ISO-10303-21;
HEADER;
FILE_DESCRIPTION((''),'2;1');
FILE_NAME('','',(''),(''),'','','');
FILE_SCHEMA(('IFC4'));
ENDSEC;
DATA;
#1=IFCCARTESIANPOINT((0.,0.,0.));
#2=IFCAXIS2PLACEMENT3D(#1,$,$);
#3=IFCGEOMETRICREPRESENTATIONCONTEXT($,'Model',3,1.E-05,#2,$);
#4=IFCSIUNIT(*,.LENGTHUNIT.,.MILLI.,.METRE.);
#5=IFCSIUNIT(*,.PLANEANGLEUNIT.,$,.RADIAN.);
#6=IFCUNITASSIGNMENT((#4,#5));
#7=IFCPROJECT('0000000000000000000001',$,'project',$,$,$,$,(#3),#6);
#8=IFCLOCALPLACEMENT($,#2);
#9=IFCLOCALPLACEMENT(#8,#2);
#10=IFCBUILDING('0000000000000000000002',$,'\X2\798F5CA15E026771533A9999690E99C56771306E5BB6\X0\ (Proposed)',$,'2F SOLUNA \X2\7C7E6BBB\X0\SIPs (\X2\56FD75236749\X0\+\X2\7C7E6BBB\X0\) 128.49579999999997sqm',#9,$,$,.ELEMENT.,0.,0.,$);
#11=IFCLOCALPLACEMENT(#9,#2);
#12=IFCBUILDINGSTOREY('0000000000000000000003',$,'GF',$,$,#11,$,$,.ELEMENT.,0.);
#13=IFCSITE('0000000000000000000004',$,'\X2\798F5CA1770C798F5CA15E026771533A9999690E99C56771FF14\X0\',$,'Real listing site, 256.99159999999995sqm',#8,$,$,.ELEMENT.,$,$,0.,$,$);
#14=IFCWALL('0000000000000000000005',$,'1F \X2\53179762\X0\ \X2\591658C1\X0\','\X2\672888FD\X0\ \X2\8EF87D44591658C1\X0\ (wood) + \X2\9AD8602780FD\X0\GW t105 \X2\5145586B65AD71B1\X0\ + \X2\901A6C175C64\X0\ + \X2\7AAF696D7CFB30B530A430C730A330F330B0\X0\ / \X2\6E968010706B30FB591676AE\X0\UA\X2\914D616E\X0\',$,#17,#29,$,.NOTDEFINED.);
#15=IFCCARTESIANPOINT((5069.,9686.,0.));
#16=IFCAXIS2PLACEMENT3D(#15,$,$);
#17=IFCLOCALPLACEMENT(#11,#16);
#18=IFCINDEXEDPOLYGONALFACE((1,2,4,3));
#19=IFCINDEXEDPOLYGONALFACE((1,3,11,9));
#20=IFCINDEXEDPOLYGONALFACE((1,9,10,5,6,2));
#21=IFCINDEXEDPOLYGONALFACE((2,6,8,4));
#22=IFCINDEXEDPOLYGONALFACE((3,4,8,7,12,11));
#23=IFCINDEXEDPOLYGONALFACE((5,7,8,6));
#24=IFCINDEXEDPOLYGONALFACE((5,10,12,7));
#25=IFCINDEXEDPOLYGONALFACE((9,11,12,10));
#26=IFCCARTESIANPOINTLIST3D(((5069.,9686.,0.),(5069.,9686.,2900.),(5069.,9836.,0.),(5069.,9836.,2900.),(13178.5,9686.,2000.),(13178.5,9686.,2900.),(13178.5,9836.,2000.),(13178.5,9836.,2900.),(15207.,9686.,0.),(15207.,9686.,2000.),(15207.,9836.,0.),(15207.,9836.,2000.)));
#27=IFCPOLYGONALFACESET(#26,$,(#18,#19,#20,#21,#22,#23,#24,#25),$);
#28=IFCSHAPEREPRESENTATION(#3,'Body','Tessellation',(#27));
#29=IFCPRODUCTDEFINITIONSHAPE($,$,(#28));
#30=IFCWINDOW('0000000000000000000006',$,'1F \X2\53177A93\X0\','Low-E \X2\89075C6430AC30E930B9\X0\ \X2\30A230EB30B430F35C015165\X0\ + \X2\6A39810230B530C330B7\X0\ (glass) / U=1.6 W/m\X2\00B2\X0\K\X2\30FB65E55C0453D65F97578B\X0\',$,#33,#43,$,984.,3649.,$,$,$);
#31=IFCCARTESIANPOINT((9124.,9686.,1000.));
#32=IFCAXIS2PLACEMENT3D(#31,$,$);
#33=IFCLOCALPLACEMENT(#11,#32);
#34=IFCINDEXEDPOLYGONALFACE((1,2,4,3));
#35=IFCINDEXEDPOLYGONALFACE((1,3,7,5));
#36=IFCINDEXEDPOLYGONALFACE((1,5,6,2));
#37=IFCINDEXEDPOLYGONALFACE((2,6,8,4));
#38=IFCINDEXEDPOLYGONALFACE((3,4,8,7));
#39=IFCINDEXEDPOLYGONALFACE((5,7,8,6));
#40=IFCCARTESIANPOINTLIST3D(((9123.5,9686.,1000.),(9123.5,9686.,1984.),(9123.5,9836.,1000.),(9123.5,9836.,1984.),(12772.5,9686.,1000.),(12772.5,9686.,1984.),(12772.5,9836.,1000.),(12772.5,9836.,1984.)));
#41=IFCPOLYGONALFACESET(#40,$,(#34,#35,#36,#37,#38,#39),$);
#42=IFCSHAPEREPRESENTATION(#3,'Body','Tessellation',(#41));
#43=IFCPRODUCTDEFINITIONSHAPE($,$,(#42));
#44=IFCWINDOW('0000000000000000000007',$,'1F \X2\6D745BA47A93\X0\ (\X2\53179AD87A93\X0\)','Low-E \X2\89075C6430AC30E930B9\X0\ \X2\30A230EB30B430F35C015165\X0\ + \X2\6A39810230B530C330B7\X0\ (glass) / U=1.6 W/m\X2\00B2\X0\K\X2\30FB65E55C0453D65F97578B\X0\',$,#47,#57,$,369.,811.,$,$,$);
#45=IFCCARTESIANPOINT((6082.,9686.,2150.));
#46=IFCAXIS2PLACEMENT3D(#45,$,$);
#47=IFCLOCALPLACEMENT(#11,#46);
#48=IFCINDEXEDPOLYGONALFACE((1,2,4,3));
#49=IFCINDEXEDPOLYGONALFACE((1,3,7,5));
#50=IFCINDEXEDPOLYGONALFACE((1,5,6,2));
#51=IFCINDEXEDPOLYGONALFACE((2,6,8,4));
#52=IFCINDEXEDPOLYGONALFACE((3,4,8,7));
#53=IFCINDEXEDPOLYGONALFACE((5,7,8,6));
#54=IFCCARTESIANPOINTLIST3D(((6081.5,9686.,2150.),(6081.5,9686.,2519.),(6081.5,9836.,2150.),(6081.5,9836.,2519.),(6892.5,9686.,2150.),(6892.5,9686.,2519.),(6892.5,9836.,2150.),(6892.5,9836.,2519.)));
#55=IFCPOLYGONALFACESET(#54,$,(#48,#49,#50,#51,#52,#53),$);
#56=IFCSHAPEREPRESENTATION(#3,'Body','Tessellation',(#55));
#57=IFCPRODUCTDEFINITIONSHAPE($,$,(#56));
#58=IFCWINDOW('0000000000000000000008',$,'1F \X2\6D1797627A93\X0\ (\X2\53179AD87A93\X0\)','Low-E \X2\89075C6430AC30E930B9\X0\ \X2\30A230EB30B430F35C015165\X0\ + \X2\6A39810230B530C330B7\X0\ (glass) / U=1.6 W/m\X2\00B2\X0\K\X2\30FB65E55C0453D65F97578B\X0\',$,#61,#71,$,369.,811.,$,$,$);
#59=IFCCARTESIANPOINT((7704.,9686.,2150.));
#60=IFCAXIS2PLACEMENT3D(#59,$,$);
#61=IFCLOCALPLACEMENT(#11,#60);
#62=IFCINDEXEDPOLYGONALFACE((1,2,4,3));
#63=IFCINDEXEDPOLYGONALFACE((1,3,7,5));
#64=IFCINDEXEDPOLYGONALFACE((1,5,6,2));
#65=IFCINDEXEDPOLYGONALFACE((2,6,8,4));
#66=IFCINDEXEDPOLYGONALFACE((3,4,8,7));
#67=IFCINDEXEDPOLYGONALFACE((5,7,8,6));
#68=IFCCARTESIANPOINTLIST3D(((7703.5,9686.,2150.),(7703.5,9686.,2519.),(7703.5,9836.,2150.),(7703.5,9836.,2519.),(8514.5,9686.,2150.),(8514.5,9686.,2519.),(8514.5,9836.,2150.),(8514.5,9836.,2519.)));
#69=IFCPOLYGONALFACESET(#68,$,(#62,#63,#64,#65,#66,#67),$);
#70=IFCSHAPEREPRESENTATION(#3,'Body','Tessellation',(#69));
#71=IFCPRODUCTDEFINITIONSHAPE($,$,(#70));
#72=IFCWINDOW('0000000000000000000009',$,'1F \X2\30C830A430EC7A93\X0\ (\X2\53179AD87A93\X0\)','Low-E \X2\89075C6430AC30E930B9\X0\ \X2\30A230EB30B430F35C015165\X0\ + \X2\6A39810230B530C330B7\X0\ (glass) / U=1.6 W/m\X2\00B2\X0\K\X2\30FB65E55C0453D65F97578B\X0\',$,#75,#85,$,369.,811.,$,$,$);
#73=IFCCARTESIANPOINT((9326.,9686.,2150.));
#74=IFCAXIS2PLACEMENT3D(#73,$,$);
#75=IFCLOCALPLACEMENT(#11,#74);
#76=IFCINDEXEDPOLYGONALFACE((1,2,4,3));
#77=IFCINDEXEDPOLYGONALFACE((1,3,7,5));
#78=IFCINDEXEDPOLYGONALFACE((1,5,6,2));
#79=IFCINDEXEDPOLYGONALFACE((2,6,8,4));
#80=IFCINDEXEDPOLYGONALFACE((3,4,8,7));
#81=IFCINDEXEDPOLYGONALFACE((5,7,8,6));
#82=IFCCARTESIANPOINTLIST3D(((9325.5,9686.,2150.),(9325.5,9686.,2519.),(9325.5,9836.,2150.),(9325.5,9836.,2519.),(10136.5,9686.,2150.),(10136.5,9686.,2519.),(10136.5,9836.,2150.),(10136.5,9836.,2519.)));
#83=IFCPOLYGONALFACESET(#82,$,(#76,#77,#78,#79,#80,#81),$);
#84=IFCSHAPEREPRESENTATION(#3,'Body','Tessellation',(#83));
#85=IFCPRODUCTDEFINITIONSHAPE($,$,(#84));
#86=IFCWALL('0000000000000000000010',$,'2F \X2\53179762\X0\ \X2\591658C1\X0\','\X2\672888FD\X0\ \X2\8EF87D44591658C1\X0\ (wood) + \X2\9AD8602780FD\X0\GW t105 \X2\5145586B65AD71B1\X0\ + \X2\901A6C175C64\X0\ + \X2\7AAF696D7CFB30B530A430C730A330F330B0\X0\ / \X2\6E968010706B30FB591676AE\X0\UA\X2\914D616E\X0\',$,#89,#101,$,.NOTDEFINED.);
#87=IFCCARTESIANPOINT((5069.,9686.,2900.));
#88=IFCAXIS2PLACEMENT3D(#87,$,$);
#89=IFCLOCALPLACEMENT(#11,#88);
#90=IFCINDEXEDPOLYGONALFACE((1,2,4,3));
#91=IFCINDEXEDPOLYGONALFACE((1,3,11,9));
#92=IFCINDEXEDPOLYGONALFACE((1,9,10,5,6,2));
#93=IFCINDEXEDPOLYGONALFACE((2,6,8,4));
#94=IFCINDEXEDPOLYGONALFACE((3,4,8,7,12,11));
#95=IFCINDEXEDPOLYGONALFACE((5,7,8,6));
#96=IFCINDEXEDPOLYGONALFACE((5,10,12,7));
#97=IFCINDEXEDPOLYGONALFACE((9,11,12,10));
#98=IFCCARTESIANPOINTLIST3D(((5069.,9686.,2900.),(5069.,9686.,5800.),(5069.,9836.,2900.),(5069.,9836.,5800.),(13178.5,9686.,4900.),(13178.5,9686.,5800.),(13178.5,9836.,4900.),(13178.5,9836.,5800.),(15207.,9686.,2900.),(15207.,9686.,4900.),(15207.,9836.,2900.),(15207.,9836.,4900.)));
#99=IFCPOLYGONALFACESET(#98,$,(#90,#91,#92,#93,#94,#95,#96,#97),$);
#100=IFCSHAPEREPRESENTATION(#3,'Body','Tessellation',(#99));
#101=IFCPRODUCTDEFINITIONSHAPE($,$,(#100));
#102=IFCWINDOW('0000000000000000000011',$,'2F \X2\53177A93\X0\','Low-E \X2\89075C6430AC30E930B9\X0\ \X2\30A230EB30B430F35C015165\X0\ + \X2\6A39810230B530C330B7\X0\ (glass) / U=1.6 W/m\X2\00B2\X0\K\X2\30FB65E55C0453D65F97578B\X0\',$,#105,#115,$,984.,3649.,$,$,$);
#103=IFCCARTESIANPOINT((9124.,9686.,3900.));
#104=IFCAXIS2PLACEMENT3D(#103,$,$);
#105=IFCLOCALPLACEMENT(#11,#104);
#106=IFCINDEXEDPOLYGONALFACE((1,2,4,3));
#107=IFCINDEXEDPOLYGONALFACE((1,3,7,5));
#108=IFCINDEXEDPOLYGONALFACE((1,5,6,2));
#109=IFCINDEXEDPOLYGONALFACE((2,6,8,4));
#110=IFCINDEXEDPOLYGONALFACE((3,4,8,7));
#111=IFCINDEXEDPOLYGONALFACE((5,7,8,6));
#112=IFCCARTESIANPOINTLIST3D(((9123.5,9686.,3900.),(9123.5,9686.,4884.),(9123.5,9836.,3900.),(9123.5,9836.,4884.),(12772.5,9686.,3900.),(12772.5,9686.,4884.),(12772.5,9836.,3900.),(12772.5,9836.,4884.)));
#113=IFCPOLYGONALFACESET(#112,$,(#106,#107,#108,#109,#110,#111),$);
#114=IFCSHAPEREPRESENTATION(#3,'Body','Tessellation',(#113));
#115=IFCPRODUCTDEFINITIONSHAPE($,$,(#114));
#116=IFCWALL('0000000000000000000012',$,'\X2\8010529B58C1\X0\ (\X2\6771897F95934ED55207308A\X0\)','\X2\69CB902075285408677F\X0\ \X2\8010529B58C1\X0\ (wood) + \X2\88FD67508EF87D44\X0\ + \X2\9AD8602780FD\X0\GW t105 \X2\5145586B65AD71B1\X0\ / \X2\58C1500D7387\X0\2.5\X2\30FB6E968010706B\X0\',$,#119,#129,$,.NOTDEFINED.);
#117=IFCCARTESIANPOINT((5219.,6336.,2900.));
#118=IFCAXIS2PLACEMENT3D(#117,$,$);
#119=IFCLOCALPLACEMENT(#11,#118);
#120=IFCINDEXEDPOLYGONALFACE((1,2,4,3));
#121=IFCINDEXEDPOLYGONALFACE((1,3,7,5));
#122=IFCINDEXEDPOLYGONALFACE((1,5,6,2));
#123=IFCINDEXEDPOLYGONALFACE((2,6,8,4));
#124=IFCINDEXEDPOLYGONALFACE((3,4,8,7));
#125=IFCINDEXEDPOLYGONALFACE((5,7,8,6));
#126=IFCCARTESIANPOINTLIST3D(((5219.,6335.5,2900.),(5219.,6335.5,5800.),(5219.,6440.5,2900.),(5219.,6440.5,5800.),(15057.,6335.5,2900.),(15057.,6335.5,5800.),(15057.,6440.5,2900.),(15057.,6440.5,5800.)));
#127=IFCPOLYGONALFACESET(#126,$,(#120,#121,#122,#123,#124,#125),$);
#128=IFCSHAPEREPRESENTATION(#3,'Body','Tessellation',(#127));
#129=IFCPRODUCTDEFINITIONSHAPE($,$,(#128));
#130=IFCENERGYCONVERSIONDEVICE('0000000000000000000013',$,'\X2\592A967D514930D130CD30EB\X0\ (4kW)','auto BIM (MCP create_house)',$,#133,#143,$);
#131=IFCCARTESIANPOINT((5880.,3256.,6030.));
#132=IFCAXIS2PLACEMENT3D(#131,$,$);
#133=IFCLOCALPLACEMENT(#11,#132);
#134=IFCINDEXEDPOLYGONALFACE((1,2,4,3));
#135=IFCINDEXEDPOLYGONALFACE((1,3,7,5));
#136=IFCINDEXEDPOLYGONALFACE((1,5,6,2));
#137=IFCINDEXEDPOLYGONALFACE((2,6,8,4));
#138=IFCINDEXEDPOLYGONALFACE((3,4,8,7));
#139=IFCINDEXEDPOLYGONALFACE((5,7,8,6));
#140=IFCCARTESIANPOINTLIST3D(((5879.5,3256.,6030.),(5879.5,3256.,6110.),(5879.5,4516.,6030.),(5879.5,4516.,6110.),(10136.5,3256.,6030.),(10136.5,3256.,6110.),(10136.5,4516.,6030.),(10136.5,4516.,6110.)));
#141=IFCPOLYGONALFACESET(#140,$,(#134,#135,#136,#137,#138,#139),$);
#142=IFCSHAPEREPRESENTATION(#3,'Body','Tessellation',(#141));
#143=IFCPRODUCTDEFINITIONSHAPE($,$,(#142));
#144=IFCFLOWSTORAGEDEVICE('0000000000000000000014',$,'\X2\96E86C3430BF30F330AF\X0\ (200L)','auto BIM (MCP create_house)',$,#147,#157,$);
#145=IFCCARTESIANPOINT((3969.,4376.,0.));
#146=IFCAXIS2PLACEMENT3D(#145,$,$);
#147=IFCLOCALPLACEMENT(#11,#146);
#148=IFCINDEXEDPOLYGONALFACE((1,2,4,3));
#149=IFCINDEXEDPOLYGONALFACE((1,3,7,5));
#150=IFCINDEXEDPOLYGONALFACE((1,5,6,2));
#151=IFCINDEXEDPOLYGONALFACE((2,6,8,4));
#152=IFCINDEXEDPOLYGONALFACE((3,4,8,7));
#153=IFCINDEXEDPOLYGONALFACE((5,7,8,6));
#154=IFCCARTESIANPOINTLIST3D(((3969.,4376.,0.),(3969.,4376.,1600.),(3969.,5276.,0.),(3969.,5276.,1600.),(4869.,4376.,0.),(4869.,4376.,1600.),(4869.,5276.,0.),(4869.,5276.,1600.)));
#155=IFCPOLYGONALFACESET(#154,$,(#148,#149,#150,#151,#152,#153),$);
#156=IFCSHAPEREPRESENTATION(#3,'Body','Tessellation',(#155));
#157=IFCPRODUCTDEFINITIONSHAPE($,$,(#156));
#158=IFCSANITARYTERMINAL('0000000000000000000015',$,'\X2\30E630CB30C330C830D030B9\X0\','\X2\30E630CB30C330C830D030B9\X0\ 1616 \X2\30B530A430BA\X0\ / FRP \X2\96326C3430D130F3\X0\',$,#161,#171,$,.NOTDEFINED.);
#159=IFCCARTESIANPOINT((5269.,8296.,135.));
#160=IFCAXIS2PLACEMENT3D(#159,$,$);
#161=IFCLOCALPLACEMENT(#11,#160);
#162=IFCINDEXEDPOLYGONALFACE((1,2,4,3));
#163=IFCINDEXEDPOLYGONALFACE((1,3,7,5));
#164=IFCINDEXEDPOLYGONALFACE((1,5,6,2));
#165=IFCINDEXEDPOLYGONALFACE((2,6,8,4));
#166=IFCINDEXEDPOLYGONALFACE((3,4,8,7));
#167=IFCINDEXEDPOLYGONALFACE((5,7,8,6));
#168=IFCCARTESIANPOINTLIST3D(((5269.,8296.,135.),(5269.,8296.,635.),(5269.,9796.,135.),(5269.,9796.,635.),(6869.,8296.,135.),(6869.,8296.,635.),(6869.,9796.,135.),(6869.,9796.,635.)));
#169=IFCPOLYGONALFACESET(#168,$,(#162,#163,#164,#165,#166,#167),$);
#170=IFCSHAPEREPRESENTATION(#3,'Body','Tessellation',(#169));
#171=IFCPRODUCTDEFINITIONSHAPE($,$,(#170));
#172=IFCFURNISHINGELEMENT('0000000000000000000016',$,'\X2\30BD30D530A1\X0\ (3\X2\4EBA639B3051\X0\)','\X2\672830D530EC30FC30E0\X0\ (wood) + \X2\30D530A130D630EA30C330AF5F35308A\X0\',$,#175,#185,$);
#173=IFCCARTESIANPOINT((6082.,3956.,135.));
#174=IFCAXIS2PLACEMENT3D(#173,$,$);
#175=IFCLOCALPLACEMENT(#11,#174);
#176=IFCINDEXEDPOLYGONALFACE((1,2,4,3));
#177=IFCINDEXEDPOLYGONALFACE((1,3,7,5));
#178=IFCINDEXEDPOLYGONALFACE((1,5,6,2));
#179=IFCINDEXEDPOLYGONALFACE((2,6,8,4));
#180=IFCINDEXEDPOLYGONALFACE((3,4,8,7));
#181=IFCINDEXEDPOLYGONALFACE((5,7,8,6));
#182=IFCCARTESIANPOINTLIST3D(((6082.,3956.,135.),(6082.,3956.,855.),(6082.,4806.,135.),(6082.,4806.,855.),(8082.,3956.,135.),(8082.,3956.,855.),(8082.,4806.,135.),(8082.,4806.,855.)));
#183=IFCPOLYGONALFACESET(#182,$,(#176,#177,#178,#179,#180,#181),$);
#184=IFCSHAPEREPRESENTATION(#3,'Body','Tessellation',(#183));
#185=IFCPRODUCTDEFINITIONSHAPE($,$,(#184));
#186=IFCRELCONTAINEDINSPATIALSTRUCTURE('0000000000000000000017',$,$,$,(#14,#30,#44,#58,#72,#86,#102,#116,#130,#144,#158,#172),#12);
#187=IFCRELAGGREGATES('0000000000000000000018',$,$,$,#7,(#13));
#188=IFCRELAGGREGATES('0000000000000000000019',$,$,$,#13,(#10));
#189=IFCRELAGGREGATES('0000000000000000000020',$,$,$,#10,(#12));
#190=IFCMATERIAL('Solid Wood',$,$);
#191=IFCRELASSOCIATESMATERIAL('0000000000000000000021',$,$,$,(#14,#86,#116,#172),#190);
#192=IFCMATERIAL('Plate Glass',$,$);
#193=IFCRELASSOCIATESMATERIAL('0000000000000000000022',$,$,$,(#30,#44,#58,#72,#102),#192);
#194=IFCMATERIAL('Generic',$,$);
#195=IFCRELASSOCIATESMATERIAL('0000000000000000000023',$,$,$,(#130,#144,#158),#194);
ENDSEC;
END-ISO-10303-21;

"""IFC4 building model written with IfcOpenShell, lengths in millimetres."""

from ifc_helpers import new_model, si_unit, frame, frame_2d, origin, place, context, project, spatial, rectangle, extrude, material, element, fill, save


model = new_model("IFC4")

# Units and contexts
model_context = context("Model", 3, precision=1e-05, world=origin())
ifc_project = project(units=[si_unit("LENGTHUNIT", "METRE", prefix="MILLI"), si_unit("PLANEANGLEUNIT", "RADIAN")], contexts=[model_context])

# Site, building, storey
site_placement = place(None, origin())
site = spatial("IfcSite", under=ifc_project, at=site_placement, Name="福岡県福岡市東区香椎駅東４", ObjectType="Real listing site, 256.99159999999995sqm", CompositionType="ELEMENT", RefElevation=0.0)
building_placement = place(site_placement, origin())
building = spatial("IfcBuilding", under=site, at=building_placement, Name="福岡市東区香椎駅東の家 (Proposed)", ObjectType="2F SOLUNA 籾殻SIPs (国産杉+籾殻) 128.49579999999997sqm", CompositionType="ELEMENT", ElevationOfRefHeight=0.0, ElevationOfTerrain=0.0)
storey_placement = place(building_placement, origin())
storey = spatial("IfcBuildingStorey", under=building, at=storey_placement, Name="GF", CompositionType="ELEMENT", Elevation=0.0)

# Wall, openings, windows
ifc_material_1 = material(Name="Solid Wood")
wall_1_placement = place(storey_placement, frame((5069.0, 9686.0, 0.0)))
wall_1 = element("IfcWall", 1, at=wall_1_placement, inside=storey, material=ifc_material_1, Name="1F 北面 外壁", Description="木製 軸組外壁 (wood) + 高性能GW t105 充填断熱 + 通気層 + 窯業系サイディング / 準耐火・外皮UA配慮", PredefinedType="NOTDEFINED", context=model_context, shape_type="SweptSolid", body=[
    extrude(rectangle(XDim=10138.0, YDim=150.0, at=frame_2d((5069.0, 75.0))), frame((5069.0, 9686.0, 0.0)), (0.0, 0.0, 1.0), 2900.0),
])
opening_1_placement = place(storey_placement, frame((9124.0, 9686.0, 1000.0)))
opening_1 = element("IfcOpeningElement", 2, at=opening_1_placement, cuts=wall_1, PredefinedType="NOTDEFINED", context=model_context, shape_type="SweptSolid", body=[
    extrude(rectangle(XDim=3649.0, YDim=150.0, at=frame_2d((1824.0, 75.0))), frame((9124.0, 9686.0, 1000.0)), (0.0, 0.0, 1.0), 984.0),
])
opening_2_placement = place(storey_placement, frame((6082.0, 9686.0, 2150.0)))
opening_2 = element("IfcOpeningElement", 3, at=opening_2_placement, cuts=wall_1, PredefinedType="NOTDEFINED", context=model_context, shape_type="SweptSolid", body=[
    extrude(rectangle(XDim=811.0, YDim=150.0, at=frame_2d((405.0, 75.0))), frame((6082.0, 9686.0, 2150.0)), (0.0, 0.0, 1.0), 369.0),
])
opening_3_placement = place(storey_placement, frame((7704.0, 9686.0, 2150.0)))
opening_3 = element("IfcOpeningElement", 4, at=opening_3_placement, cuts=wall_1, PredefinedType="NOTDEFINED", context=model_context, shape_type="SweptSolid", body=[
    extrude(rectangle(XDim=811.0, YDim=150.0, at=frame_2d((405.0, 75.0))), frame((7704.0, 9686.0, 2150.0)), (0.0, 0.0, 1.0), 369.0),
])
opening_4_placement = place(storey_placement, frame((9326.0, 9686.0, 2150.0)))
opening_4 = element("IfcOpeningElement", 5, at=opening_4_placement, cuts=wall_1, PredefinedType="NOTDEFINED", context=model_context, shape_type="SweptSolid", body=[
    extrude(rectangle(XDim=811.0, YDim=150.0, at=frame_2d((405.0, 75.0))), frame((9326.0, 9686.0, 2150.0)), (0.0, 0.0, 1.0), 369.0),
])
ifc_material_2 = material(Name="Plate Glass")
window_1_placement = place(storey_placement, frame((9124.0, 9686.0, 1000.0)))
window_1 = element("IfcWindow", 6, at=window_1_placement, inside=storey, material=ifc_material_2, Name="1F 北窓", Description="Low-E 複層ガラス アルゴン封入 + 樹脂サッシ (glass) / U=1.6 W/m²K・日射取得型", OverallHeight=984.0, OverallWidth=3649.0, context=model_context, shape_type="SweptSolid", body=[
    extrude(rectangle(XDim=3649.0, YDim=150.0, at=frame_2d((1824.0, 75.0))), frame((9124.0, 9686.0, 1000.0)), (0.0, 0.0, 1.0), 984.0),
])
fill(opening_1, window_1)
window_2_placement = place(storey_placement, frame((6082.0, 9686.0, 2150.0)))
window_2 = element("IfcWindow", 7, at=window_2_placement, inside=storey, material=ifc_material_2, Name="1F 浴室窓 (北高窓)", Description="Low-E 複層ガラス アルゴン封入 + 樹脂サッシ (glass) / U=1.6 W/m²K・日射取得型", OverallHeight=369.0, OverallWidth=811.0, context=model_context, shape_type="SweptSolid", body=[
    extrude(rectangle(XDim=811.0, YDim=150.0, at=frame_2d((405.0, 75.0))), frame((6082.0, 9686.0, 2150.0)), (0.0, 0.0, 1.0), 369.0),
])
fill(opening_2, window_2)
window_3_placement = place(storey_placement, frame((7704.0, 9686.0, 2150.0)))
window_3 = element("IfcWindow", 8, at=window_3_placement, inside=storey, material=ifc_material_2, Name="1F 洗面窓 (北高窓)", Description="Low-E 複層ガラス アルゴン封入 + 樹脂サッシ (glass) / U=1.6 W/m²K・日射取得型", OverallHeight=369.0, OverallWidth=811.0, context=model_context, shape_type="SweptSolid", body=[
    extrude(rectangle(XDim=811.0, YDim=150.0, at=frame_2d((405.0, 75.0))), frame((7704.0, 9686.0, 2150.0)), (0.0, 0.0, 1.0), 369.0),
])
fill(opening_3, window_3)
window_4_placement = place(storey_placement, frame((9326.0, 9686.0, 2150.0)))
window_4 = element("IfcWindow", 9, at=window_4_placement, inside=storey, material=ifc_material_2, Name="1F トイレ窓 (北高窓)", Description="Low-E 複層ガラス アルゴン封入 + 樹脂サッシ (glass) / U=1.6 W/m²K・日射取得型", OverallHeight=369.0, OverallWidth=811.0, context=model_context, shape_type="SweptSolid", body=[
    extrude(rectangle(XDim=811.0, YDim=150.0, at=frame_2d((405.0, 75.0))), frame((9326.0, 9686.0, 2150.0)), (0.0, 0.0, 1.0), 369.0),
])
fill(opening_4, window_4)

# Wall, opening, window
wall_2_placement = place(storey_placement, frame((5069.0, 9686.0, 2900.0)))
wall_2 = element("IfcWall", 10, at=wall_2_placement, inside=storey, material=ifc_material_1, Name="2F 北面 外壁", Description="木製 軸組外壁 (wood) + 高性能GW t105 充填断熱 + 通気層 + 窯業系サイディング / 準耐火・外皮UA配慮", PredefinedType="NOTDEFINED", context=model_context, shape_type="SweptSolid", body=[
    extrude(rectangle(XDim=10138.0, YDim=150.0, at=frame_2d((5069.0, 75.0))), frame((5069.0, 9686.0, 2900.0)), (0.0, 0.0, 1.0), 2900.0),
])
opening_5_placement = place(storey_placement, frame((9124.0, 9686.0, 3900.0)))
opening_5 = element("IfcOpeningElement", 11, at=opening_5_placement, cuts=wall_2, PredefinedType="NOTDEFINED", context=model_context, shape_type="SweptSolid", body=[
    extrude(rectangle(XDim=3649.0, YDim=150.0, at=frame_2d((1824.0, 75.0))), frame((9124.0, 9686.0, 3900.0)), (0.0, 0.0, 1.0), 984.0),
])
window_5_placement = place(storey_placement, frame((9124.0, 9686.0, 3900.0)))
window_5 = element("IfcWindow", 12, at=window_5_placement, inside=storey, material=ifc_material_2, Name="2F 北窓", Description="Low-E 複層ガラス アルゴン封入 + 樹脂サッシ (glass) / U=1.6 W/m²K・日射取得型", OverallHeight=984.0, OverallWidth=3649.0, context=model_context, shape_type="SweptSolid", body=[
    extrude(rectangle(XDim=3649.0, YDim=150.0, at=frame_2d((1824.0, 75.0))), frame((9124.0, 9686.0, 3900.0)), (0.0, 0.0, 1.0), 984.0),
])
fill(opening_5, window_5)

# Wall
wall_3_placement = place(storey_placement, frame((5219.0, 6336.0, 2900.0)))
element("IfcWall", 13, at=wall_3_placement, inside=storey, material=ifc_material_1, Name="耐力壁 (東西間仕切り)", Description="構造用合板 耐力壁 (wood) + 製材軸組 + 高性能GW t105 充填断熱 / 壁倍率2.5・準耐火", PredefinedType="NOTDEFINED", context=model_context, shape_type="SweptSolid", body=[
    extrude(rectangle(XDim=9838.0, YDim=105.0, at=frame_2d((4919.0, 52.0))), frame((5219.0, 6336.0, 2900.0)), (0.0, 0.0, 1.0), 2900.0),
])

# Energy conversion device
ifc_material_3 = material(Name="Generic")
energy_conversion_device_placement = place(storey_placement, frame((5880.0, 3256.0, 6030.0)))
element("IfcEnergyConversionDevice", 14, at=energy_conversion_device_placement, inside=storey, material=ifc_material_3, Name="太陽光パネル (4kW)", Description="auto BIM (MCP create_house)", context=model_context, shape_type="SweptSolid", body=[
    extrude(rectangle(XDim=4257.0, YDim=1260.0, at=frame_2d((2128.0, 630.0))), frame((5880.0, 3256.0, 6030.0)), (0.0, 0.0, 1.0), 80.0),
])

# Flow storage device
flow_storage_device_placement = place(storey_placement, frame((3969.0, 4376.0, 0.0)))
element("IfcFlowStorageDevice", 15, at=flow_storage_device_placement, inside=storey, material=ifc_material_3, Name="雨水タンク (200L)", Description="auto BIM (MCP create_house)", context=model_context, shape_type="SweptSolid", body=[
    extrude(rectangle(XDim=900.0, YDim=900.0, at=frame_2d((450.0, 450.0))), frame((3969.0, 4376.0, 0.0)), (0.0, 0.0, 1.0), 1600.0),
])

# Sanitary terminal
sanitary_terminal_placement = place(storey_placement, frame((5269.0, 8296.0, 135.0)))
element("IfcSanitaryTerminal", 16, at=sanitary_terminal_placement, inside=storey, material=ifc_material_3, Name="ユニットバス", Description="ユニットバス 1616 サイズ / FRP 防水パン", PredefinedType="NOTDEFINED", context=model_context, shape_type="SweptSolid", body=[
    extrude(rectangle(XDim=1600.0, YDim=1500.0, at=frame_2d((800.0, 750.0))), frame((5269.0, 8296.0, 135.0)), (0.0, 0.0, 1.0), 500.0),
])

# Furnishing element
furnishing_1_placement = place(storey_placement, frame((6082.0, 3956.0, 135.0)))
element("IfcFurnishingElement", 17, at=furnishing_1_placement, inside=storey, material=ifc_material_1, Name="ソファ (3人掛け)", Description="木フレーム (wood) + ファブリック張り", context=model_context, shape_type="SweptSolid", body=[
    extrude(rectangle(XDim=2000.0, YDim=850.0, at=frame_2d((1000.0, 425.0))), frame((6082.0, 3956.0, 135.0)), (0.0, 0.0, 1.0), 720.0),
])

save(model, "model.ifc")
